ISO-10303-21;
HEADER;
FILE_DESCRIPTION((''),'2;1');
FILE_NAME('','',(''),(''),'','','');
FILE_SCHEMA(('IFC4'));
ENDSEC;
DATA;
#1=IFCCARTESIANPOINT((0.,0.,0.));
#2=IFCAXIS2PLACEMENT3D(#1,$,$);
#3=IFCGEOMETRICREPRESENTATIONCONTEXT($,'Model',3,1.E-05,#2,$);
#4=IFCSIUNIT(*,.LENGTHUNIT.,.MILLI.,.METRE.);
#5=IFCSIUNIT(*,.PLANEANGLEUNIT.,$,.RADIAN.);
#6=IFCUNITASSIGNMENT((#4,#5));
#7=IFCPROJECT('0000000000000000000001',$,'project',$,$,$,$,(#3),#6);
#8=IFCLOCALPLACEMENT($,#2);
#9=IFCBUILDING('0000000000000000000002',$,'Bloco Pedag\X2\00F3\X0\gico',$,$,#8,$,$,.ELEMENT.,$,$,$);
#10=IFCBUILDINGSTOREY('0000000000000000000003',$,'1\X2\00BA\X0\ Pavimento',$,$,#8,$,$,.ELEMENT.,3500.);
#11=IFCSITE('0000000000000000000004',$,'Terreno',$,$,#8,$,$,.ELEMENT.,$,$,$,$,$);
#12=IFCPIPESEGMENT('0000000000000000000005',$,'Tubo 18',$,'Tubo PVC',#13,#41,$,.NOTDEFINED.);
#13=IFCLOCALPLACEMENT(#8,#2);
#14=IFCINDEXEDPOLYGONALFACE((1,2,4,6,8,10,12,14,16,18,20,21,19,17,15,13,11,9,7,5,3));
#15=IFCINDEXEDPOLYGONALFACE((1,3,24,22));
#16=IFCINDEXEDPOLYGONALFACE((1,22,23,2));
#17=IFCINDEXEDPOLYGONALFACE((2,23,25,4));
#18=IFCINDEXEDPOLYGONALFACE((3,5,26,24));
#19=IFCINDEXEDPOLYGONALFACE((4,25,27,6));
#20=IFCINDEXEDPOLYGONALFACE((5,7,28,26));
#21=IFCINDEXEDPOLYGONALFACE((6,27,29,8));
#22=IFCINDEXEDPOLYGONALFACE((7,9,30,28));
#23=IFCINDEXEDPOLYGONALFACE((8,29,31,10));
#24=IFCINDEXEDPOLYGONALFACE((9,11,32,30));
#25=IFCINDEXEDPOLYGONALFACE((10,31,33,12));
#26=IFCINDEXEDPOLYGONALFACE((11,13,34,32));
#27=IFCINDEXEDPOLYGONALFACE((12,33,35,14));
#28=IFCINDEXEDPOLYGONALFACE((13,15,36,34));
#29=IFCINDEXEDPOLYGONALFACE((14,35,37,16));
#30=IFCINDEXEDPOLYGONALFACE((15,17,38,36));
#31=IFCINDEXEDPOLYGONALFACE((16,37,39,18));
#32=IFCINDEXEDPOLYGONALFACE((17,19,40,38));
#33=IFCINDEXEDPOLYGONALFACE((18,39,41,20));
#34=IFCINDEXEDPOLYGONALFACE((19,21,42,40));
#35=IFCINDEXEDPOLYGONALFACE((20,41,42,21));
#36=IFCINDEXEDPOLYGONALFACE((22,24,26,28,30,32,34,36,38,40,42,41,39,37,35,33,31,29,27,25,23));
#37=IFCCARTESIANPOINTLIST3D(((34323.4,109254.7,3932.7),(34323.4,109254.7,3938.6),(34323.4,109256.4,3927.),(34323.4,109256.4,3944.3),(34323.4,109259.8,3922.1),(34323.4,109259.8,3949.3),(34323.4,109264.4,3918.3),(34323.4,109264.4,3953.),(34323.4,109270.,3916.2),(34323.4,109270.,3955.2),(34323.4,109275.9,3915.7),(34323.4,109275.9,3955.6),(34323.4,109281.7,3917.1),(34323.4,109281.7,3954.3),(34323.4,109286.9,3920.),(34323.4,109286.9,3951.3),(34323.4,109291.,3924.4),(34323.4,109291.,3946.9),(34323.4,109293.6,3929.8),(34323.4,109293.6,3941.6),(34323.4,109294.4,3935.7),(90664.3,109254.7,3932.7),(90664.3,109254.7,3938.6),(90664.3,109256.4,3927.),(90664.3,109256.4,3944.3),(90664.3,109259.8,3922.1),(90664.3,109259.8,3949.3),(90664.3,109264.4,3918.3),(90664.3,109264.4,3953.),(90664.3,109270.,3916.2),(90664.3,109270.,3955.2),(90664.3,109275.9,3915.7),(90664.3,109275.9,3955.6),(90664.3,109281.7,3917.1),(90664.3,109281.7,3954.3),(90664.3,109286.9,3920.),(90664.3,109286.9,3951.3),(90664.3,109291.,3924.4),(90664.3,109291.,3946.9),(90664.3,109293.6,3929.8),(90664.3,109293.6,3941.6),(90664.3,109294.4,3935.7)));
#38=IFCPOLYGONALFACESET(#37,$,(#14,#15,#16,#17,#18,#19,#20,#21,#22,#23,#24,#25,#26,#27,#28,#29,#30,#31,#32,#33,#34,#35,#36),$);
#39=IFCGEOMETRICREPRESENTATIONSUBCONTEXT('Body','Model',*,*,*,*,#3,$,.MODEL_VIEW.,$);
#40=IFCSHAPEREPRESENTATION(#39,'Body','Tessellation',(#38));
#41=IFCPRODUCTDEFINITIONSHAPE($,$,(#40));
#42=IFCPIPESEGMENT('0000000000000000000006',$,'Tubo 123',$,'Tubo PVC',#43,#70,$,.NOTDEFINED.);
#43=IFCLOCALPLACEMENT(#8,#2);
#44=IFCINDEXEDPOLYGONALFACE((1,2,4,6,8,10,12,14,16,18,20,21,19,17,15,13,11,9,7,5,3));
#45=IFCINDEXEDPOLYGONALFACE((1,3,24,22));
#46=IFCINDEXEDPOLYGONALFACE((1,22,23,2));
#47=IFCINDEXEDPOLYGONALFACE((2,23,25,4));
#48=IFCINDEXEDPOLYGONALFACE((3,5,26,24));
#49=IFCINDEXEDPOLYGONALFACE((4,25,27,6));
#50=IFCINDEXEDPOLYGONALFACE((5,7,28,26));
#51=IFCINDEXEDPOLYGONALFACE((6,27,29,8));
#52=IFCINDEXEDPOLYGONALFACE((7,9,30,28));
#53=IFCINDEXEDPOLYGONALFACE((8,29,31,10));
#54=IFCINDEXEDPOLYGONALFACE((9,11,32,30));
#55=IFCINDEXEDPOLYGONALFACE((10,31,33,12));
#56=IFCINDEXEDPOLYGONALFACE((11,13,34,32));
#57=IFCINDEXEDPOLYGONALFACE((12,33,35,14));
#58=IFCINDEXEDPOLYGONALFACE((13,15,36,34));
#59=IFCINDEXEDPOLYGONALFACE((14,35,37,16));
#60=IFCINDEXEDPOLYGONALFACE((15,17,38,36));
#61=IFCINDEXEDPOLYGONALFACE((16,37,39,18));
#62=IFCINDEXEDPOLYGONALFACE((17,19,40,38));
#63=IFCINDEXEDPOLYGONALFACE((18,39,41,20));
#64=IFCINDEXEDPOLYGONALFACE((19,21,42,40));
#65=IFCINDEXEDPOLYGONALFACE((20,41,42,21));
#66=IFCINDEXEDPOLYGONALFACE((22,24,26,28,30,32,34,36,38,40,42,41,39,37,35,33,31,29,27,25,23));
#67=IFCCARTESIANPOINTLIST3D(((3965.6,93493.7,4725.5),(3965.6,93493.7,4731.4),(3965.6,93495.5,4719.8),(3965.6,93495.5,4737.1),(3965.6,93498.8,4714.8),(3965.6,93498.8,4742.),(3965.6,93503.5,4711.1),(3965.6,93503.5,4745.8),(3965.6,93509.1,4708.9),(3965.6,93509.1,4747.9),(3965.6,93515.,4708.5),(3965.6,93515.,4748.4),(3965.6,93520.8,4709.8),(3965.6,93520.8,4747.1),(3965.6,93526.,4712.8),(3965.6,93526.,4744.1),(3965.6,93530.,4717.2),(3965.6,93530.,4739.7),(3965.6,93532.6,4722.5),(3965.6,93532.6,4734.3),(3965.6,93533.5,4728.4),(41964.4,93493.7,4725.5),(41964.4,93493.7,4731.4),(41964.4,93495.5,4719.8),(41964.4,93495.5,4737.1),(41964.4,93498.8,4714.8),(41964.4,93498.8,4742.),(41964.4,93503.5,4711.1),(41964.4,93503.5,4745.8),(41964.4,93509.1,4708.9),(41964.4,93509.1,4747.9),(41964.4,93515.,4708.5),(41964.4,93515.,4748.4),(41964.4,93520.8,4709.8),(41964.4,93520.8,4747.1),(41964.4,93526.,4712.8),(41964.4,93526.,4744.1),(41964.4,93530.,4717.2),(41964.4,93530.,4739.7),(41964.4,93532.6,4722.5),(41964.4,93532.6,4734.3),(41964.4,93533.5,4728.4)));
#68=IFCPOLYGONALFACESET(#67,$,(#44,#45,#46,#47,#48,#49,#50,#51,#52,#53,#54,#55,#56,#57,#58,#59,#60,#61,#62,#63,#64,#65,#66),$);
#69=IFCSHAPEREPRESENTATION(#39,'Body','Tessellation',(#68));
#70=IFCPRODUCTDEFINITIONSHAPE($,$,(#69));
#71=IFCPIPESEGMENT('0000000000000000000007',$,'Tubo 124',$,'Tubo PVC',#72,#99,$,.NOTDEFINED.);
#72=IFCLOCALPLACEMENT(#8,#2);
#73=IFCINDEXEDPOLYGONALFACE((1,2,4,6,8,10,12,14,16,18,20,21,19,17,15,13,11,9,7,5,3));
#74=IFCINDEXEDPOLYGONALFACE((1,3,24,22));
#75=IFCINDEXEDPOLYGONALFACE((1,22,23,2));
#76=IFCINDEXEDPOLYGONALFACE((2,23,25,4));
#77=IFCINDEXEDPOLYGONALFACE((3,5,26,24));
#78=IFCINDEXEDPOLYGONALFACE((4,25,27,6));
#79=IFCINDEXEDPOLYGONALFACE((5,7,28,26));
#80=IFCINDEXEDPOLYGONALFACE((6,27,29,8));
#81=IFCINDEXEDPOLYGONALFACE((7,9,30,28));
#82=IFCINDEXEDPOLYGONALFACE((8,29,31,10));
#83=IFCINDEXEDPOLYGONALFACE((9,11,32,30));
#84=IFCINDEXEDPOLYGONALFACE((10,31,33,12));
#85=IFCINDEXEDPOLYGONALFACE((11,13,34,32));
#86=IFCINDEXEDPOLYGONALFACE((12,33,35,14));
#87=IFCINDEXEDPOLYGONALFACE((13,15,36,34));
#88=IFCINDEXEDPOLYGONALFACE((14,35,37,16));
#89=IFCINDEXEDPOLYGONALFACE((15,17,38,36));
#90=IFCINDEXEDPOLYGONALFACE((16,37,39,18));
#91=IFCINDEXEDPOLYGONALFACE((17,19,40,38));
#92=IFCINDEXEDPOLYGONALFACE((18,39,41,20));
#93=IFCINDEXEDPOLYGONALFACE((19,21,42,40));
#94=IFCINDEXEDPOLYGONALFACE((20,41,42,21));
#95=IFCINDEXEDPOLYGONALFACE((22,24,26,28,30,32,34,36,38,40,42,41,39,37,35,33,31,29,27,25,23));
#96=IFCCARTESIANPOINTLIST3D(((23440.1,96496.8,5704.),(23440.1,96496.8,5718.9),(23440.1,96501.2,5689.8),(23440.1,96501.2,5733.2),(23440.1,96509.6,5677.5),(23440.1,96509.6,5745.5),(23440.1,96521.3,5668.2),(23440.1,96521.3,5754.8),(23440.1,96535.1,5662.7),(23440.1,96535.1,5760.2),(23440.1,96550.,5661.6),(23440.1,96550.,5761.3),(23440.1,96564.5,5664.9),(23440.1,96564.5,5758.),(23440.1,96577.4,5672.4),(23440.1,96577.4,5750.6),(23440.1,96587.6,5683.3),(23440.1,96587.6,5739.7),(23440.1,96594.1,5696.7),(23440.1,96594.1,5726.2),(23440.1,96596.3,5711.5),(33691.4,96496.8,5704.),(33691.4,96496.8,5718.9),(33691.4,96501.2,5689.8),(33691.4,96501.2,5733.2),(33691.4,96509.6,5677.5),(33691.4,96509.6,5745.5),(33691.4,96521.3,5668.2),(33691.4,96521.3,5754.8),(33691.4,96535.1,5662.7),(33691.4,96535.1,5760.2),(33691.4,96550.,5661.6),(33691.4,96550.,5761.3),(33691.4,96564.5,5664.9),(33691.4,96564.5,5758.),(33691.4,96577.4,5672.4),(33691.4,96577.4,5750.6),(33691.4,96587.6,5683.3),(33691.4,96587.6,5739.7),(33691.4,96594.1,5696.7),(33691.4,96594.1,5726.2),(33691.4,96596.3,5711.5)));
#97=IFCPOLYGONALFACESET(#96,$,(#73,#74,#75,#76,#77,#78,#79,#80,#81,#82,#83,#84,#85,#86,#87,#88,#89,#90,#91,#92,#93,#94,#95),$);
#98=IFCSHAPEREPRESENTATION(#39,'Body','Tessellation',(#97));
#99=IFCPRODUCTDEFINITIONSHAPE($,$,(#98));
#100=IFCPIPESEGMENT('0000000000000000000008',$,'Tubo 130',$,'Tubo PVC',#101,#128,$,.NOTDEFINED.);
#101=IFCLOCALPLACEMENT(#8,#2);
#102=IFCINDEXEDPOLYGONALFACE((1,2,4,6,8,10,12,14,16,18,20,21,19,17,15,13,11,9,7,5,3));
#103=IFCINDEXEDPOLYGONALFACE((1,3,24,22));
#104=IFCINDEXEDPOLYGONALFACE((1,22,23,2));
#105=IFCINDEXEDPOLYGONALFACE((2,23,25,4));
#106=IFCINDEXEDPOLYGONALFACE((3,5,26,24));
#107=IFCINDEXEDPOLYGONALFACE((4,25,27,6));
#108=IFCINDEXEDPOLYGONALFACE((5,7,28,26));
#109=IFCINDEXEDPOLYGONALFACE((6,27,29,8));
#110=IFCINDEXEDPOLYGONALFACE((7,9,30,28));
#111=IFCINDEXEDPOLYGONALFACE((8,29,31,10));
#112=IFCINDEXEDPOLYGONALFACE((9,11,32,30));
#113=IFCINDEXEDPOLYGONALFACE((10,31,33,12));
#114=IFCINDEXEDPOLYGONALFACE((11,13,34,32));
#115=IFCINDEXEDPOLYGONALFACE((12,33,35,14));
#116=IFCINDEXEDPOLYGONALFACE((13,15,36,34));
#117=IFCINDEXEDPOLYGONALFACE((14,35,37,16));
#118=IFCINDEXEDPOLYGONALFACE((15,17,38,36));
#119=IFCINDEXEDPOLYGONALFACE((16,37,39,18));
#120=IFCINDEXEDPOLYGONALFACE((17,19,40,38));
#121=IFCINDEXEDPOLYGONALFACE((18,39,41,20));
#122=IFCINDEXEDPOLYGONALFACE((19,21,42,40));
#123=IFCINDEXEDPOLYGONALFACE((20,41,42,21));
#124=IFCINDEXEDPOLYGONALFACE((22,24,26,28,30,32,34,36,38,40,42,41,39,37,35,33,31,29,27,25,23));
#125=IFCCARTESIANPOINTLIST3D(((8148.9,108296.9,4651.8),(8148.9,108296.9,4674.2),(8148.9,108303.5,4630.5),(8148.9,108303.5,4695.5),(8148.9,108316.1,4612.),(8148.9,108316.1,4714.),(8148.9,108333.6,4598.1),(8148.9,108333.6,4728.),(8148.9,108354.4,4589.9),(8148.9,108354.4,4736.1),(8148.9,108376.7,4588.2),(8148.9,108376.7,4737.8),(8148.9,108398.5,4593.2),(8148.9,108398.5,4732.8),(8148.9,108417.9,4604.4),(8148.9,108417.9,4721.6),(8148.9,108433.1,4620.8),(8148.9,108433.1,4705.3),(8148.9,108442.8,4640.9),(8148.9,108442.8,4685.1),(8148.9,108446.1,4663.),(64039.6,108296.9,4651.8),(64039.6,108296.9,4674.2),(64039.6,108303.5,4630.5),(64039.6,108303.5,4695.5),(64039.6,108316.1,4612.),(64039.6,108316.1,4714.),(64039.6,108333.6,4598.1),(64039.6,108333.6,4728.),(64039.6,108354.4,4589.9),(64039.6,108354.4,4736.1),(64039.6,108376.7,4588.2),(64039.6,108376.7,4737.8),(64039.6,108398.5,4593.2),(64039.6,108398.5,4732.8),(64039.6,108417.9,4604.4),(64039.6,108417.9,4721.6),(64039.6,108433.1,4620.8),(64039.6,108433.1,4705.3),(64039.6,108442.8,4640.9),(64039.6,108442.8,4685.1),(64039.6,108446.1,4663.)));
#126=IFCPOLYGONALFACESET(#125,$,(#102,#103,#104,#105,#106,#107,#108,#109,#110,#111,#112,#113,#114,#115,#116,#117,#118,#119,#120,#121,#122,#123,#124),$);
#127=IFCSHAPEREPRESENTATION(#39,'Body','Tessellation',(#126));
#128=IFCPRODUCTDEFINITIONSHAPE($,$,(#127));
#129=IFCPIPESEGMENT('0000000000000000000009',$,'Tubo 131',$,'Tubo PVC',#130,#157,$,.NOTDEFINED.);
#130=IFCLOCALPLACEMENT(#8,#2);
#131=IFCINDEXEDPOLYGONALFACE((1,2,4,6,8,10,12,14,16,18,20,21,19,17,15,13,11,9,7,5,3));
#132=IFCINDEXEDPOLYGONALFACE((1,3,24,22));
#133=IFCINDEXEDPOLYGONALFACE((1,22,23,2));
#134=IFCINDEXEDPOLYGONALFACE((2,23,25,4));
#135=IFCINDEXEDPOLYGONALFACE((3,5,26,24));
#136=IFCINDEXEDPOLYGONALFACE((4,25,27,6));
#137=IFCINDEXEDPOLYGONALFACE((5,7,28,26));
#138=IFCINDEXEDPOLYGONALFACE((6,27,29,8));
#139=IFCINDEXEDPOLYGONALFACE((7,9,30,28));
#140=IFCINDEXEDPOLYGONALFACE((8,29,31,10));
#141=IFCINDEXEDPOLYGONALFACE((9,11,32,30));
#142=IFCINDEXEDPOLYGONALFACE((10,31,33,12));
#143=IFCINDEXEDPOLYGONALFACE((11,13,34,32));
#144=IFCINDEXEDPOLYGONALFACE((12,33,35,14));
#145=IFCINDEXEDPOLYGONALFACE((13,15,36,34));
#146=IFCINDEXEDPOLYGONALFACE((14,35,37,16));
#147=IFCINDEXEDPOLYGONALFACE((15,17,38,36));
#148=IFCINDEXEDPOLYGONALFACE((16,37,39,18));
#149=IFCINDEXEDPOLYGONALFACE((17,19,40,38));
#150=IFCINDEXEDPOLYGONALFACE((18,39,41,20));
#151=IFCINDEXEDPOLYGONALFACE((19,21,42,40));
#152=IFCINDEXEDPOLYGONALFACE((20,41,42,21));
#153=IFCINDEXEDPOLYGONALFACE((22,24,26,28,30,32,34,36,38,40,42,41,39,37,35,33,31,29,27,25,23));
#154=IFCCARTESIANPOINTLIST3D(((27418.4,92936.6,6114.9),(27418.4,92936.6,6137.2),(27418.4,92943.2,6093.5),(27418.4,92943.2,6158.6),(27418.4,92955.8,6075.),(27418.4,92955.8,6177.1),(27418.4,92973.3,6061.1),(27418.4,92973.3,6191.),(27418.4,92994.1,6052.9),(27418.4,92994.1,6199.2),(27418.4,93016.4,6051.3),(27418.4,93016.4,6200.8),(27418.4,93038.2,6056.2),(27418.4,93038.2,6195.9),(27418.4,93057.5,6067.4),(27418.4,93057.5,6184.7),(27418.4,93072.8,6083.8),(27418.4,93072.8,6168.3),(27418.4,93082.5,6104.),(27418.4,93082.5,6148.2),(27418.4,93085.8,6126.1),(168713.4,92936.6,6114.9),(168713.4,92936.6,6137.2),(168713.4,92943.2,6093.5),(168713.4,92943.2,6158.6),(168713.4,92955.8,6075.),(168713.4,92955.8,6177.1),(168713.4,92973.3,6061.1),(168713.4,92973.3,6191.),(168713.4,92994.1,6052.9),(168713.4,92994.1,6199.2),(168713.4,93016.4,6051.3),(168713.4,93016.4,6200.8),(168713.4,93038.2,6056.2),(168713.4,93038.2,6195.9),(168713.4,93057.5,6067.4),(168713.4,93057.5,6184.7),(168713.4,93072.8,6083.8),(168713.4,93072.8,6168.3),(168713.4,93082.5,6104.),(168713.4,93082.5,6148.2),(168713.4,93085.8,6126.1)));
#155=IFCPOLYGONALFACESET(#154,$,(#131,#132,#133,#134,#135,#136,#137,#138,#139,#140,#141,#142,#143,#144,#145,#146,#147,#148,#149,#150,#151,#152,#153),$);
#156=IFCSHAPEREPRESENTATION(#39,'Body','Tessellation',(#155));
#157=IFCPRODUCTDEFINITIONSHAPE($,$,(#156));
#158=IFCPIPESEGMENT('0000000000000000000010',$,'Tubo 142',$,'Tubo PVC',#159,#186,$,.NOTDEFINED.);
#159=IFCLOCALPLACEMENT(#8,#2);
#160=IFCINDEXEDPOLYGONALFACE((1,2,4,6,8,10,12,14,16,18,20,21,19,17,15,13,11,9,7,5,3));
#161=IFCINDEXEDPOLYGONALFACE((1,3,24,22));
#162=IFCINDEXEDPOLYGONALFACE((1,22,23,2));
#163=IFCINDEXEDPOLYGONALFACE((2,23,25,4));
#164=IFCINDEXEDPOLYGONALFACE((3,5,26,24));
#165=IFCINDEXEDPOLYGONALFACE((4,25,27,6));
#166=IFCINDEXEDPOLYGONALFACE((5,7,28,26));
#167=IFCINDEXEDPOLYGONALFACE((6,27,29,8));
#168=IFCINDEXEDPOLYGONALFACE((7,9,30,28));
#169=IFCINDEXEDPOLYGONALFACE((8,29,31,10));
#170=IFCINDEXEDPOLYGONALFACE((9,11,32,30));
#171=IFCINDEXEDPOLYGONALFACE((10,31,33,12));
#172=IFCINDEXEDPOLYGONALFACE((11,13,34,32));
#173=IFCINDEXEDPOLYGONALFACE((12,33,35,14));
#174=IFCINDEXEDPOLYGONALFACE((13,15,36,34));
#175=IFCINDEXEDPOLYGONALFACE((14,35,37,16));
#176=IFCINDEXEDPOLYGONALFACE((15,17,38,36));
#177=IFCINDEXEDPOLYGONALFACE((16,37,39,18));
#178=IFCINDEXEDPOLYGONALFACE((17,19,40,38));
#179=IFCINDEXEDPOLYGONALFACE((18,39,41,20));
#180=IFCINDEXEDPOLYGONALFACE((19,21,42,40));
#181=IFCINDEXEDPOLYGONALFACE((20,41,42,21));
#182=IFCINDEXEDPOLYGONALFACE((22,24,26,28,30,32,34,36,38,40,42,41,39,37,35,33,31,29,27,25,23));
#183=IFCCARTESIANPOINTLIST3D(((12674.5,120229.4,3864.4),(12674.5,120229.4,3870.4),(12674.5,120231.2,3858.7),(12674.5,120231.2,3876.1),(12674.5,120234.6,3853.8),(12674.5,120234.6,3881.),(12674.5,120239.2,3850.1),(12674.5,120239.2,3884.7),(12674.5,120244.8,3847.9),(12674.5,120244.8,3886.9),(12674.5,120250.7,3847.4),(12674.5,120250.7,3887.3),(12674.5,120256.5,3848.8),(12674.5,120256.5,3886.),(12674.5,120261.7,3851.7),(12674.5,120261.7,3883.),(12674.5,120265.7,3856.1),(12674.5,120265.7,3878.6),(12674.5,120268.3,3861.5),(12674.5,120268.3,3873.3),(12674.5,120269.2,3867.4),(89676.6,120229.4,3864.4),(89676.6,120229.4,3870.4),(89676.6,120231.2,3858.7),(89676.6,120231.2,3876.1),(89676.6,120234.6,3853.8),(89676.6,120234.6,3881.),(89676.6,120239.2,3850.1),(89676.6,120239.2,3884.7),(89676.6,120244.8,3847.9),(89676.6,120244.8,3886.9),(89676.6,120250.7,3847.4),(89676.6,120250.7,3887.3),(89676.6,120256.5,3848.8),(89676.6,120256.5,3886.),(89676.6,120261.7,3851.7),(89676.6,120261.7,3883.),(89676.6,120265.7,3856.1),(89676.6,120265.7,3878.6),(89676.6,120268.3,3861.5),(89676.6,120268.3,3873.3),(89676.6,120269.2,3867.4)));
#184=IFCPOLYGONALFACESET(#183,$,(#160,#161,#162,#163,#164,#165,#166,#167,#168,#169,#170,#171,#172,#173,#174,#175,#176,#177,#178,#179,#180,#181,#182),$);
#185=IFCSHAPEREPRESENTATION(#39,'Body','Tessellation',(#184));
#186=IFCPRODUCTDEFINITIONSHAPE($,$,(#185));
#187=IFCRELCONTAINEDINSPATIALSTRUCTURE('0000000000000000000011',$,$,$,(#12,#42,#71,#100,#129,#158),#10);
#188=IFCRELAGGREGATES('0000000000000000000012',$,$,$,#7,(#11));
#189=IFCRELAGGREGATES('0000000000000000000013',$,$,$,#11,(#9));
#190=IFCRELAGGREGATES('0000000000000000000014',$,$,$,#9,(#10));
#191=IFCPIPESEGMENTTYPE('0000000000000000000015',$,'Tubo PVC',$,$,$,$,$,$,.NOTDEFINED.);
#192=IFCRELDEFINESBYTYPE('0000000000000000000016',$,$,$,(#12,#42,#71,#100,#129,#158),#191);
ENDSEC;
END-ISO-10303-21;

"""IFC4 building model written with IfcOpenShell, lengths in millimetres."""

from ifc_helpers import new_model, si_unit, frame, origin, origin_2d, place, context, subcontext, project, spatial, circle, extrude, type_object, element, save


model = new_model("IFC4")

# Units and contexts
model_context = context("Model", 3, precision=1e-05, world=origin())
body_context = subcontext(model_context, "Body", "Model", "MODEL_VIEW")
ifc_project = project(units=[si_unit("LENGTHUNIT", "METRE", prefix="MILLI"), si_unit("PLANEANGLEUNIT", "RADIAN")], contexts=[model_context])

# Site, building, storey
placement = place(None, origin())
site = spatial("IfcSite", under=ifc_project, at=placement, Name="Terreno", CompositionType="ELEMENT")
building = spatial("IfcBuilding", under=site, at=placement, Name="Bloco Pedagógico", CompositionType="ELEMENT")
storey = spatial("IfcBuildingStorey", under=building, at=placement, Name="1º Pavimento", CompositionType="ELEMENT", Elevation=3500.0)

# Pipe segments
pipe_segment_type = type_object("IfcPipeSegmentType", Name="Tubo PVC", PredefinedType="NOTDEFINED")
pipe_segment_1_placement = place(None, frame((34323.4, 109274.4, 3935.7), z_axis=(1.0, 0.0, 0.0), x_axis=(0.0, 1.0, 0.0)))
element("IfcPipeSegment", 1, at=pipe_segment_1_placement, inside=storey, type_object=pipe_segment_type, Name="Tubo 18", ObjectType="Tubo PVC", PredefinedType="NOTDEFINED", context=body_context, shape_type="SweptSolid", body=[
    extrude(circle(Radius=20.0, at=origin_2d()), None, (0.0, 0.0, 1.0), 56340.9),
])
pipe_segment_2_placement = place(None, frame((3965.6, 93513.5, 4728.4), z_axis=(1.0, 0.0, 0.0), x_axis=(0.0, 1.0, 0.0)))
element("IfcPipeSegment", 2, at=pipe_segment_2_placement, inside=storey, type_object=pipe_segment_type, Name="Tubo 123", ObjectType="Tubo PVC", PredefinedType="NOTDEFINED", context=body_context, shape_type="SweptSolid", body=[
    extrude(circle(Radius=20.0, at=origin_2d()), None, (0.0, 0.0, 1.0), 37998.8),
])
pipe_segment_3_placement = place(None, frame((23440.1, 96546.3, 5711.5), z_axis=(1.0, 0.0, 0.0), x_axis=(0.0, 1.0, 0.0)))
element("IfcPipeSegment", 3, at=pipe_segment_3_placement, inside=storey, type_object=pipe_segment_type, Name="Tubo 124", ObjectType="Tubo PVC", PredefinedType="NOTDEFINED", context=body_context, shape_type="SweptSolid", body=[
    extrude(circle(Radius=50.0, at=origin_2d()), None, (0.0, 0.0, 1.0), 10251.3),
])
pipe_segment_4_placement = place(None, frame((8148.9, 108371.1, 4663.0), z_axis=(1.0, 0.0, 0.0), x_axis=(0.0, 1.0, 0.0)))
element("IfcPipeSegment", 4, at=pipe_segment_4_placement, inside=storey, type_object=pipe_segment_type, Name="Tubo 130", ObjectType="Tubo PVC", PredefinedType="NOTDEFINED", context=body_context, shape_type="SweptSolid", body=[
    extrude(circle(Radius=75.0, at=origin_2d()), None, (0.0, 0.0, 1.0), 55890.7),
])
pipe_segment_5_placement = place(None, frame((27418.4, 93010.8, 6126.1), z_axis=(1.0, 0.0, 0.0), x_axis=(0.0, 1.0, 0.0)))
element("IfcPipeSegment", 5, at=pipe_segment_5_placement, inside=storey, type_object=pipe_segment_type, Name="Tubo 131", ObjectType="Tubo PVC", PredefinedType="NOTDEFINED", context=body_context, shape_type="SweptSolid", body=[
    extrude(circle(Radius=75.0, at=origin_2d()), None, (0.0, 0.0, 1.0), 141295.0),
])
pipe_segment_6_placement = place(None, frame((12674.5, 120249.2, 3867.4), z_axis=(1.0, 0.0, 0.0), x_axis=(0.0, 1.0, 0.0)))
element("IfcPipeSegment", 6, at=pipe_segment_6_placement, inside=storey, type_object=pipe_segment_type, Name="Tubo 142", ObjectType="Tubo PVC", PredefinedType="NOTDEFINED", context=body_context, shape_type="SweptSolid", body=[
    extrude(circle(Radius=20.0, at=origin_2d()), None, (0.0, 0.0, 1.0), 77002.1),
])

save(model, "model.ifc")
